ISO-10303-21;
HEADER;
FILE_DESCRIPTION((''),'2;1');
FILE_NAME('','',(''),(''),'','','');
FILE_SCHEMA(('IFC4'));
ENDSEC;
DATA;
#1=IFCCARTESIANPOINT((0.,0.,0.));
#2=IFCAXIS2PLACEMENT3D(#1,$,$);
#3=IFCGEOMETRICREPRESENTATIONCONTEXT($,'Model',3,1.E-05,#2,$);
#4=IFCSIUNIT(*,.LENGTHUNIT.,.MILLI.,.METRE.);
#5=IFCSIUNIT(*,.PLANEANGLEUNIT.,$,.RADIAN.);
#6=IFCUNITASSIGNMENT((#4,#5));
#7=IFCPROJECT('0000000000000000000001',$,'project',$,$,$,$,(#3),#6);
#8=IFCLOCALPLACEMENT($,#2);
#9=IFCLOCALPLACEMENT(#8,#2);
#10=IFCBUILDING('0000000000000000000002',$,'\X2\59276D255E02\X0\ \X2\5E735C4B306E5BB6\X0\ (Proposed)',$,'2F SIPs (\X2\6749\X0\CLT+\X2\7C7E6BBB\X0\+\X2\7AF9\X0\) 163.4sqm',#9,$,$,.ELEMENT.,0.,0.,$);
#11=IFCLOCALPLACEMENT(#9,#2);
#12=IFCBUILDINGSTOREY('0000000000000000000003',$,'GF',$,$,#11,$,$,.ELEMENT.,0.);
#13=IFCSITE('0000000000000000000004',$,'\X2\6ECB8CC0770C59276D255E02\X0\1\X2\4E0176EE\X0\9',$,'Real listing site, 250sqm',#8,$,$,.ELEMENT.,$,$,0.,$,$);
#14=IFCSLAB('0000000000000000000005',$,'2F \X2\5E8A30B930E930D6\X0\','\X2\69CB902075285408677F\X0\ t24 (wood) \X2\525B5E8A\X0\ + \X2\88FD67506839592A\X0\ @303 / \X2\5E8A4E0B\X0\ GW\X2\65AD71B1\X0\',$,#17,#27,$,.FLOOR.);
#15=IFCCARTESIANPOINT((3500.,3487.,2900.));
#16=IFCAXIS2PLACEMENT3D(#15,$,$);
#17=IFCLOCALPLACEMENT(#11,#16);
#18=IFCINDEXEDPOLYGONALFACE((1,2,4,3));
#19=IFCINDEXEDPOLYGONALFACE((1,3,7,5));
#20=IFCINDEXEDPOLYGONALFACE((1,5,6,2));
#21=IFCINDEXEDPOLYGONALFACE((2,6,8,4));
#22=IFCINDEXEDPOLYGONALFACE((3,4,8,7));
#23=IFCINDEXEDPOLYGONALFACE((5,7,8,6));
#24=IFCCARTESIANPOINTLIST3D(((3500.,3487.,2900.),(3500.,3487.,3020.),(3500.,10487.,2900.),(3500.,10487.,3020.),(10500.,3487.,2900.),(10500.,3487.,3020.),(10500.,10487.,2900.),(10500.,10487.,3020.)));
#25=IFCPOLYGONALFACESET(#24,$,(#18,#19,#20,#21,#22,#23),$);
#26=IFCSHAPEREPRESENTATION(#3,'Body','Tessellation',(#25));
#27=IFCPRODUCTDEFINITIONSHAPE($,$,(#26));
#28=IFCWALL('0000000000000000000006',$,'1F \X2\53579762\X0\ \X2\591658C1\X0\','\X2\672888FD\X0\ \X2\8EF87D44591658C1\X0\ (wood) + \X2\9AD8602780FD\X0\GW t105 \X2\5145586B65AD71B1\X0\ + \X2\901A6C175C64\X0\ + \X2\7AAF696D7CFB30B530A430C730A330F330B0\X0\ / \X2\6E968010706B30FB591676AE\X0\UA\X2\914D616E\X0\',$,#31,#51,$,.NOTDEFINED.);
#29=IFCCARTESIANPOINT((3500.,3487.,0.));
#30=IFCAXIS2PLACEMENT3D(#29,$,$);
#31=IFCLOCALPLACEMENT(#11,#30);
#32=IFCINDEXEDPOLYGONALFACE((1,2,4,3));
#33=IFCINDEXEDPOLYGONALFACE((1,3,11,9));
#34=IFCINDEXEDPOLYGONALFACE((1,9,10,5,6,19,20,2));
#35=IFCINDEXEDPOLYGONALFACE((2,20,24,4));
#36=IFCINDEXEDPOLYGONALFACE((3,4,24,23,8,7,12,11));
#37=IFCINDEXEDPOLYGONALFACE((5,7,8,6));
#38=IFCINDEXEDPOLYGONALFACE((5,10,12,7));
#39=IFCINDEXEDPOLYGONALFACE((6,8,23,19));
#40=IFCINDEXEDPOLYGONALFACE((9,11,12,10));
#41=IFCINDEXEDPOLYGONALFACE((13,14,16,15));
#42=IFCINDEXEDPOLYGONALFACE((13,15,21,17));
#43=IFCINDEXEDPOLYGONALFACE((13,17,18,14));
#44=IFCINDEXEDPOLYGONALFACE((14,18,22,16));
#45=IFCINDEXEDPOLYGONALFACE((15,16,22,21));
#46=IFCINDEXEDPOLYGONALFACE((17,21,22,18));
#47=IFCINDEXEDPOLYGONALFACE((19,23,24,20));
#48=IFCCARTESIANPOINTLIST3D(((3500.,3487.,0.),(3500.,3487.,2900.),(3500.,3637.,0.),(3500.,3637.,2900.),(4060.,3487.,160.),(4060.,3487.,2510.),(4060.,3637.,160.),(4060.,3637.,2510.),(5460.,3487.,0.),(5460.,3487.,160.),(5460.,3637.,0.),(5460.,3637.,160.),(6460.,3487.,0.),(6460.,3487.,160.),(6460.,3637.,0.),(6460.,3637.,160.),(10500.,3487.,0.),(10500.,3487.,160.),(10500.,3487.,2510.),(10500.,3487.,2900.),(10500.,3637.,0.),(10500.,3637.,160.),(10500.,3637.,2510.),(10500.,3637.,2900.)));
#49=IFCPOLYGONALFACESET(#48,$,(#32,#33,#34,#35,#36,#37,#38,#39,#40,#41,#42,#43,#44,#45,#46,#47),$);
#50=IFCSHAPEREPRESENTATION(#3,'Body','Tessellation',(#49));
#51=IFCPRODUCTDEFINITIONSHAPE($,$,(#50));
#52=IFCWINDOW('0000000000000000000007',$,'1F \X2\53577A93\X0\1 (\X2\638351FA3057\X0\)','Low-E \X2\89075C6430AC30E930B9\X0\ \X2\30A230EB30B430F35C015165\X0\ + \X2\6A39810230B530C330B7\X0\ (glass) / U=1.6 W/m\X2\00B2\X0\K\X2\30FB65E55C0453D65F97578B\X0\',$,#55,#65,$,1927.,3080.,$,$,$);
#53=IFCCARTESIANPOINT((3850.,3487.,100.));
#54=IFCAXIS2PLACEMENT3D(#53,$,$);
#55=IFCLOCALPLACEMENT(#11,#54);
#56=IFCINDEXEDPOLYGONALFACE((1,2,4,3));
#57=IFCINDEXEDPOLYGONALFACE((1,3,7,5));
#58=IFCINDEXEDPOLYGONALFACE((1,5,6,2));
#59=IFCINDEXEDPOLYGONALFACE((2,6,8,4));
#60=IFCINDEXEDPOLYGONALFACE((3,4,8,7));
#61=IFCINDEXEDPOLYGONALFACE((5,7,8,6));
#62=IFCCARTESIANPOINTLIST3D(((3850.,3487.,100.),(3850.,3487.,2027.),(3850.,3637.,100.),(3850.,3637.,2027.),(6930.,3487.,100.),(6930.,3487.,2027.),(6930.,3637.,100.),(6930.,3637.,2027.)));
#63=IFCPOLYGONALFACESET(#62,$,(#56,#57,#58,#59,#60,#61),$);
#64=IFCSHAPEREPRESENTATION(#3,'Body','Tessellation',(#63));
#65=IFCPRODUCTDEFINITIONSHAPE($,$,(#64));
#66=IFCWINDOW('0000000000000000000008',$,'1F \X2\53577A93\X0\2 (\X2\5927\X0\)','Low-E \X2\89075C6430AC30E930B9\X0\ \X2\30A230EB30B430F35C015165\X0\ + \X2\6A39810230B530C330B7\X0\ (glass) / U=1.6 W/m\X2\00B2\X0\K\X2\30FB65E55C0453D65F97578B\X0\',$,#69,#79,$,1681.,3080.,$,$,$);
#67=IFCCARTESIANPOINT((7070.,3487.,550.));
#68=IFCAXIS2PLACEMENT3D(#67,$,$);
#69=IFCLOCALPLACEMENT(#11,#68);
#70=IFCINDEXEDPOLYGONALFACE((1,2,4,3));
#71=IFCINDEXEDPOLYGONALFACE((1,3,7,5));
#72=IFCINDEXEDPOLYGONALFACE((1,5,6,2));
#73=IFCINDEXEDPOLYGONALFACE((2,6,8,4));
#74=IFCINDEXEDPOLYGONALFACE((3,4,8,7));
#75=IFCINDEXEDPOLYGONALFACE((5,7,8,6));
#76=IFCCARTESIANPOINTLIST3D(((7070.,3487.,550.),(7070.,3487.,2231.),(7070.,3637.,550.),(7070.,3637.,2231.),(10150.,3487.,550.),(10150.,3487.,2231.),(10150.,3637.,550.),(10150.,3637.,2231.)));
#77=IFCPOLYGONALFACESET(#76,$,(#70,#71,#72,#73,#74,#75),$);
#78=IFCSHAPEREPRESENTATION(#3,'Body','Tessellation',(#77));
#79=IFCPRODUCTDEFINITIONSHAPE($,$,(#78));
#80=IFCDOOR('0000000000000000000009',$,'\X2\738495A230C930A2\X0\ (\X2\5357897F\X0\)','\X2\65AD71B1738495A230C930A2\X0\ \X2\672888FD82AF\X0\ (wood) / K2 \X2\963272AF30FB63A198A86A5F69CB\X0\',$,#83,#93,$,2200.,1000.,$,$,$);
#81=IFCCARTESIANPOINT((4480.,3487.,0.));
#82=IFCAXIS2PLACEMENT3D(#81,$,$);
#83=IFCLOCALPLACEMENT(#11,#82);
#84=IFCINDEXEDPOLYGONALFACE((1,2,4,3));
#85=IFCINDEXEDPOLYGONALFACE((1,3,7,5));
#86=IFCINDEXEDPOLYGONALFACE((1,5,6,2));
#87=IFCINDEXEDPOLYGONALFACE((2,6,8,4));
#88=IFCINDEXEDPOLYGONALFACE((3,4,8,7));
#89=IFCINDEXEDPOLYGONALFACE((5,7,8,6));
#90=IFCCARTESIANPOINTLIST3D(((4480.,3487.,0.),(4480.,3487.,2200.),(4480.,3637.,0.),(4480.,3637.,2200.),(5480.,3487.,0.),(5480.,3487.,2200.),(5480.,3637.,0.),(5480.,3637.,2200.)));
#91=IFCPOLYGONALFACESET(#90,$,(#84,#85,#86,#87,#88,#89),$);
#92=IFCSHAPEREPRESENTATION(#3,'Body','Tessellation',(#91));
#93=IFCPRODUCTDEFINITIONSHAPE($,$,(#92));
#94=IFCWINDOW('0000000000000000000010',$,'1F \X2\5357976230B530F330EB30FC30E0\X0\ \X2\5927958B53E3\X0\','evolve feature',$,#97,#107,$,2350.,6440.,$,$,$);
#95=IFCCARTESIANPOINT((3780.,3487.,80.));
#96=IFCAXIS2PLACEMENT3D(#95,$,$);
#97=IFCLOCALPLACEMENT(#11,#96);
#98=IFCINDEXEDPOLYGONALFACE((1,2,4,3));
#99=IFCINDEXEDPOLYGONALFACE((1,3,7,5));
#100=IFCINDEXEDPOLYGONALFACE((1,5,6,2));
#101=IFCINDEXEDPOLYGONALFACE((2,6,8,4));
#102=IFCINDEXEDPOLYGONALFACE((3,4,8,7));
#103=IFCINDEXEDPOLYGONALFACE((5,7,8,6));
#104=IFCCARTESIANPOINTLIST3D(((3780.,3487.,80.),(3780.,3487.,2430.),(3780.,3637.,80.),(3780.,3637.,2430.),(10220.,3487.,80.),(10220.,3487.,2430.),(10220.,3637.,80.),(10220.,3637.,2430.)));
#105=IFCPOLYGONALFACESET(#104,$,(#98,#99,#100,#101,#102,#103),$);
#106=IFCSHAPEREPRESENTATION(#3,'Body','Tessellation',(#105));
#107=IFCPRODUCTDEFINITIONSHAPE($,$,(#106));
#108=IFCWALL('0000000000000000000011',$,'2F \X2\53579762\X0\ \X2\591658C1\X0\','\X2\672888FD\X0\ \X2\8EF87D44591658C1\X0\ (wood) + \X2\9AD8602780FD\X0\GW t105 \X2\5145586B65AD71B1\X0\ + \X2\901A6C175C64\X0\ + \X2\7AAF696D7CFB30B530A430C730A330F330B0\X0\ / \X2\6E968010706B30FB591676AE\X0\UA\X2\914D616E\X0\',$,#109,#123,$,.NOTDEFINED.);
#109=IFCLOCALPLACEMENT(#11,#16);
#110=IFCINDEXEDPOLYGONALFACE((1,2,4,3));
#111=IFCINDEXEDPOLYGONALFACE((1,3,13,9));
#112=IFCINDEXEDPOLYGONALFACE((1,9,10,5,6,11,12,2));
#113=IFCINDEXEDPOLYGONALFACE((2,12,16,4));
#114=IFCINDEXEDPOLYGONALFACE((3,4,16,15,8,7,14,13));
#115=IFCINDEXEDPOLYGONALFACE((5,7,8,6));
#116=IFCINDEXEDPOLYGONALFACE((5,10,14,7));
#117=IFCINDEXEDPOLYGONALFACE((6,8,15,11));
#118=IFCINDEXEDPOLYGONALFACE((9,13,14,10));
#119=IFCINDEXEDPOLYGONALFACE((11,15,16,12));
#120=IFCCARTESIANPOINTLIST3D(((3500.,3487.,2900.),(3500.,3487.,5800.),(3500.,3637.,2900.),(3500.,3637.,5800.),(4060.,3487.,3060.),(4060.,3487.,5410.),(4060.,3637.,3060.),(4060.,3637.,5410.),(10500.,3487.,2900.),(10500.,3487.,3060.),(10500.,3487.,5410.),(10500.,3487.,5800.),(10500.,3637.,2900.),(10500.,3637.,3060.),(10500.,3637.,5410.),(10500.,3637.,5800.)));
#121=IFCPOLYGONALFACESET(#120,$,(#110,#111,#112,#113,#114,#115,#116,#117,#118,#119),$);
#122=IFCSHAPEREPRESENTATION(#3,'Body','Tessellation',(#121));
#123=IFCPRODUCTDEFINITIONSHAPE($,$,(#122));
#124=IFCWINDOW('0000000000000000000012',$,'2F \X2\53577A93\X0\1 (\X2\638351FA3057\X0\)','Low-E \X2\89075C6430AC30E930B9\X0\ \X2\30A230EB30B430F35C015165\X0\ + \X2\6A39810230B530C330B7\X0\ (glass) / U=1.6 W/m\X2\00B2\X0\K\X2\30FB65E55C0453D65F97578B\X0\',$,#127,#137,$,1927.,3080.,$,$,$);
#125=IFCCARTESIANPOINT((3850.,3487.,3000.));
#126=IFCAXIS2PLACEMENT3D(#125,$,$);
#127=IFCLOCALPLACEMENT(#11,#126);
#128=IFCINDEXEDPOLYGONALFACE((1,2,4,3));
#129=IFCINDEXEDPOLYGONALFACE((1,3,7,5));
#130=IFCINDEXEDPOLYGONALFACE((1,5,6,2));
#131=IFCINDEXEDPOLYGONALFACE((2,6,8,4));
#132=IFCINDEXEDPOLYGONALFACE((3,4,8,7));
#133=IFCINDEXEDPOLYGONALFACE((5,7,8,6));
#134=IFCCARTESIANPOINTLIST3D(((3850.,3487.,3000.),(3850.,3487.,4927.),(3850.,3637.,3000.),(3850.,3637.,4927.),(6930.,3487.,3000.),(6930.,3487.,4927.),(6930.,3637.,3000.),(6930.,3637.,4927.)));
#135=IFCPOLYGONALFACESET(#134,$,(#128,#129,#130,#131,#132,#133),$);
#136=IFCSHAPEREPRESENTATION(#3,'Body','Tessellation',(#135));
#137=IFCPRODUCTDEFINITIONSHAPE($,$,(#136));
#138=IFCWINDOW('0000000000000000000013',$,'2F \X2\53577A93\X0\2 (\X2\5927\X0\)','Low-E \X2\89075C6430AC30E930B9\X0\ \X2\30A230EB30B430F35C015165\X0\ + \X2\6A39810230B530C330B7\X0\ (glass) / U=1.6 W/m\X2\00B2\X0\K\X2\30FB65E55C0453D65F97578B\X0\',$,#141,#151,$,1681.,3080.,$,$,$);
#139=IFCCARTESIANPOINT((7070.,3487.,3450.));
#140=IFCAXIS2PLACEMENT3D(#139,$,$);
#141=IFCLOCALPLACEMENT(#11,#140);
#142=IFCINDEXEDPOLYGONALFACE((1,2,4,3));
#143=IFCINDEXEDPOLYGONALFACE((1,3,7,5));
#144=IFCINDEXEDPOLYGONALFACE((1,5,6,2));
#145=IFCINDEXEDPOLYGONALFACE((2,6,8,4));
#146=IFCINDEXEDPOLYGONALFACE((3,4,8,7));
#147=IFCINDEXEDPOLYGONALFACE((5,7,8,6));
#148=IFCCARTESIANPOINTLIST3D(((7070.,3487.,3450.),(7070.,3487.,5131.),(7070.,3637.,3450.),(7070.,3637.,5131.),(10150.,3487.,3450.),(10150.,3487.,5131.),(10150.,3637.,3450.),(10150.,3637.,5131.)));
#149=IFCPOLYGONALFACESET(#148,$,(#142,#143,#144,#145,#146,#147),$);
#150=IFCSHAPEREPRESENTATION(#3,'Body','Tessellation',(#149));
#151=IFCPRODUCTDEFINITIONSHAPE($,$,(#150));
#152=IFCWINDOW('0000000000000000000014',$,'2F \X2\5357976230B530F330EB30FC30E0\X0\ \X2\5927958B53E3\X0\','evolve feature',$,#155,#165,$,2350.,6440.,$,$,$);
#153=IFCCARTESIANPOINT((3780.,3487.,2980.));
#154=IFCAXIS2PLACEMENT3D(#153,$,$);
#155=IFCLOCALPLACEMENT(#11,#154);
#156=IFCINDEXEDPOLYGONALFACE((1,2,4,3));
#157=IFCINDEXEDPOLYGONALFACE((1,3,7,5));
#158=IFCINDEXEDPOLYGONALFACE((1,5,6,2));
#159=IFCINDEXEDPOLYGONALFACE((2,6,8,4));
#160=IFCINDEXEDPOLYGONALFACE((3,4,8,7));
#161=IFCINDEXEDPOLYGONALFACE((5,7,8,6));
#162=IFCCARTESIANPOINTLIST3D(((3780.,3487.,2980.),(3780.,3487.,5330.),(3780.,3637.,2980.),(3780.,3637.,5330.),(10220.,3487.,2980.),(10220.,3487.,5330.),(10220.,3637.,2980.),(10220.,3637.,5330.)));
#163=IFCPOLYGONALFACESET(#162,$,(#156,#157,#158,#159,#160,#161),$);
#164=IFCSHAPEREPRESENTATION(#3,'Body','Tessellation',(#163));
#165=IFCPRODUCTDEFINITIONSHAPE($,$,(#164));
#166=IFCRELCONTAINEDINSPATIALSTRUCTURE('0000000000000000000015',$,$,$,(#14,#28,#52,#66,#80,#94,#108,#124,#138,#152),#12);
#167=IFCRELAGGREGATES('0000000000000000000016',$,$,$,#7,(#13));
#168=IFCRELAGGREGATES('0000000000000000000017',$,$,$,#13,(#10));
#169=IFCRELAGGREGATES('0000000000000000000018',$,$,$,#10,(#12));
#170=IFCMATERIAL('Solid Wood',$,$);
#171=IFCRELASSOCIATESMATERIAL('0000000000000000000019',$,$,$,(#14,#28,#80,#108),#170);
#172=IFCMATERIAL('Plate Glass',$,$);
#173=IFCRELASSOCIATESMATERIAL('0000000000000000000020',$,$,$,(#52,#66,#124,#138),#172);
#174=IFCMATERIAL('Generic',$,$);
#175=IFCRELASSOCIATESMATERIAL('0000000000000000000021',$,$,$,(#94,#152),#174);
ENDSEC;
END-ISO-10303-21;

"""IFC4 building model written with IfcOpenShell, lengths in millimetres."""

from ifc_helpers import new_model, si_unit, frame, frame_2d, origin, place, context, project, spatial, rectangle, extrude, material, element, fill, save


model = new_model("IFC4")

# Units and contexts
model_context = context("Model", 3, precision=1e-05, world=origin())
ifc_project = project(units=[si_unit("LENGTHUNIT", "METRE", prefix="MILLI"), si_unit("PLANEANGLEUNIT", "RADIAN")], contexts=[model_context])

# Site, building, storey
site_placement = place(None, origin())
site = spatial("IfcSite", under=ifc_project, at=site_placement, Name="滋賀県大津市1丁目9", ObjectType="Real listing site, 250sqm", CompositionType="ELEMENT", RefElevation=0.0)
building_placement = place(site_placement, origin())
building = spatial("IfcBuilding", under=site, at=building_placement, Name="大津市 平屋の家 (Proposed)", ObjectType="2F SIPs (杉CLT+籾殻+竹) 163.4sqm", CompositionType="ELEMENT", ElevationOfRefHeight=0.0, ElevationOfTerrain=0.0)
storey_placement = place(building_placement, origin())
storey = spatial("IfcBuildingStorey", under=building, at=storey_placement, Name="GF", CompositionType="ELEMENT", Elevation=0.0)

# Slab
ifc_material_1 = material(Name="Solid Wood")
slab_1_placement = place(storey_placement, frame((3500.0, 3487.0, 2900.0)))
element("IfcSlab", 1, at=slab_1_placement, inside=storey, material=ifc_material_1, Name="2F 床スラブ", Description="構造用合板 t24 (wood) 剛床 + 製材根太 @303 / 床下 GW断熱", PredefinedType="FLOOR", context=model_context, shape_type="SweptSolid", body=[
    extrude(rectangle(XDim=7000.0, YDim=7000.0, at=frame_2d((3500.0, 3500.0))), frame((3500.0, 3487.0, 2900.0)), (0.0, 0.0, 1.0), 120.0),
])
ifc_material_2 = material(Name="Generic")

# Wall, openings, windows, door
wall_1_placement = place(storey_placement, frame((3500.0, 3487.0, 0.0)))
wall_1 = element("IfcWall", 2, at=wall_1_placement, inside=storey, material=ifc_material_1, Name="1F 南面 外壁", Description="木製 軸組外壁 (wood) + 高性能GW t105 充填断熱 + 通気層 + 窯業系サイディング / 準耐火・外皮UA配慮", PredefinedType="NOTDEFINED", context=model_context, shape_type="SweptSolid", body=[
    extrude(rectangle(XDim=7000.0, YDim=150.0, at=frame_2d((3500.0, 75.0))), frame((3500.0, 3487.0, 0.0)), (0.0, 0.0, 1.0), 2900.0),
])
opening_1_placement = place(storey_placement, frame((3850.0, 3487.0, 100.0)))
opening_1 = element("IfcOpeningElement", 3, at=opening_1_placement, cuts=wall_1, PredefinedType="NOTDEFINED", context=model_context, shape_type="SweptSolid", body=[
    extrude(rectangle(XDim=3080.0, YDim=150.0, at=frame_2d((1540.0, 75.0))), frame((3850.0, 3487.0, 100.0)), (0.0, 0.0, 1.0), 1927.0),
])
opening_2_placement = place(storey_placement, frame((7070.0, 3487.0, 550.0)))
opening_2 = element("IfcOpeningElement", 4, at=opening_2_placement, cuts=wall_1, PredefinedType="NOTDEFINED", context=model_context, shape_type="SweptSolid", body=[
    extrude(rectangle(XDim=3080.0, YDim=150.0, at=frame_2d((1540.0, 75.0))), frame((7070.0, 3487.0, 550.0)), (0.0, 0.0, 1.0), 1681.0),
])
opening_3_placement = place(storey_placement, frame((4480.0, 3487.0, 0.0)))
opening_3 = element("IfcOpeningElement", 5, at=opening_3_placement, cuts=wall_1, PredefinedType="NOTDEFINED", context=model_context, shape_type="SweptSolid", body=[
    extrude(rectangle(XDim=1000.0, YDim=150.0, at=frame_2d((500.0, 75.0))), frame((4480.0, 3487.0, 0.0)), (0.0, 0.0, 1.0), 2200.0),
])
opening_4_placement = place(storey_placement, frame((3780.0, 3487.0, 80.0)))
opening_4 = element("IfcOpeningElement", 6, at=opening_4_placement, cuts=wall_1, PredefinedType="NOTDEFINED", context=model_context, shape_type="SweptSolid", body=[
    extrude(rectangle(XDim=6440.0, YDim=150.0, at=frame_2d((3220.0, 75.0))), frame((3780.0, 3487.0, 80.0)), (0.0, 0.0, 1.0), 2350.0),
])
ifc_material_3 = material(Name="Plate Glass")
window_1_placement = place(storey_placement, frame((3850.0, 3487.0, 100.0)))
window_1 = element("IfcWindow", 7, at=window_1_placement, inside=storey, material=ifc_material_3, Name="1F 南窓1 (掃出し)", Description="Low-E 複層ガラス アルゴン封入 + 樹脂サッシ (glass) / U=1.6 W/m²K・日射取得型", OverallHeight=1927.0, OverallWidth=3080.0, context=model_context, shape_type="SweptSolid", body=[
    extrude(rectangle(XDim=3080.0, YDim=150.0, at=frame_2d((1540.0, 75.0))), frame((3850.0, 3487.0, 100.0)), (0.0, 0.0, 1.0), 1927.0),
])
fill(opening_1, window_1)
window_2_placement = place(storey_placement, frame((7070.0, 3487.0, 550.0)))
window_2 = element("IfcWindow", 8, at=window_2_placement, inside=storey, material=ifc_material_3, Name="1F 南窓2 (大)", Description="Low-E 複層ガラス アルゴン封入 + 樹脂サッシ (glass) / U=1.6 W/m²K・日射取得型", OverallHeight=1681.0, OverallWidth=3080.0, context=model_context, shape_type="SweptSolid", body=[
    extrude(rectangle(XDim=3080.0, YDim=150.0, at=frame_2d((1540.0, 75.0))), frame((7070.0, 3487.0, 550.0)), (0.0, 0.0, 1.0), 1681.0),
])
fill(opening_2, window_2)
door_placement = place(storey_placement, frame((4480.0, 3487.0, 0.0)))
door = element("IfcDoor", 9, at=door_placement, inside=storey, material=ifc_material_1, Name="玄関ドア (南西)", Description="断熱玄関ドア 木製芯 (wood) / K2 防犯・採風機構", OverallHeight=2200.0, OverallWidth=1000.0, context=model_context, shape_type="SweptSolid", body=[
    extrude(rectangle(XDim=1000.0, YDim=150.0, at=frame_2d((500.0, 75.0))), frame((4480.0, 3487.0, 0.0)), (0.0, 0.0, 1.0), 2200.0),
])
fill(opening_3, door)
window_3_placement = place(storey_placement, frame((3780.0, 3487.0, 80.0)))
window_3 = element("IfcWindow", 10, at=window_3_placement, inside=storey, material=ifc_material_2, Name="1F 南面サンルーム 大開口", Description="evolve feature", OverallHeight=2350.0, OverallWidth=6440.0, context=model_context, shape_type="SweptSolid", body=[
    extrude(rectangle(XDim=6440.0, YDim=150.0, at=frame_2d((3220.0, 75.0))), frame((3780.0, 3487.0, 80.0)), (0.0, 0.0, 1.0), 2350.0),
])
fill(opening_4, window_3)

# Wall, openings, windows
wall_2_placement = place(storey_placement, frame((3500.0, 3487.0, 2900.0)))
wall_2 = element("IfcWall", 11, at=wall_2_placement, inside=storey, material=ifc_material_1, Name="2F 南面 外壁", Description="木製 軸組外壁 (wood) + 高性能GW t105 充填断熱 + 通気層 + 窯業系サイディング / 準耐火・外皮UA配慮", PredefinedType="NOTDEFINED", context=model_context, shape_type="SweptSolid", body=[
    extrude(rectangle(XDim=7000.0, YDim=150.0, at=frame_2d((3500.0, 75.0))), frame((3500.0, 3487.0, 2900.0)), (0.0, 0.0, 1.0), 2900.0),
])
opening_5_placement = place(storey_placement, frame((3850.0, 3487.0, 3000.0)))
opening_5 = element("IfcOpeningElement", 12, at=opening_5_placement, cuts=wall_2, PredefinedType="NOTDEFINED", context=model_context, shape_type="SweptSolid", body=[
    extrude(rectangle(XDim=3080.0, YDim=150.0, at=frame_2d((1540.0, 75.0))), frame((3850.0, 3487.0, 3000.0)), (0.0, 0.0, 1.0), 1927.0),
])
opening_6_placement = place(storey_placement, frame((7070.0, 3487.0, 3450.0)))
opening_6 = element("IfcOpeningElement", 13, at=opening_6_placement, cuts=wall_2, PredefinedType="NOTDEFINED", context=model_context, shape_type="SweptSolid", body=[
    extrude(rectangle(XDim=3080.0, YDim=150.0, at=frame_2d((1540.0, 75.0))), frame((7070.0, 3487.0, 3450.0)), (0.0, 0.0, 1.0), 1681.0),
])
opening_7_placement = place(storey_placement, frame((3780.0, 3487.0, 2980.0)))
opening_7 = element("IfcOpeningElement", 14, at=opening_7_placement, cuts=wall_2, PredefinedType="NOTDEFINED", context=model_context, shape_type="SweptSolid", body=[
    extrude(rectangle(XDim=6440.0, YDim=150.0, at=frame_2d((3220.0, 75.0))), frame((3780.0, 3487.0, 2980.0)), (0.0, 0.0, 1.0), 2350.0),
])
window_4_placement = place(storey_placement, frame((3850.0, 3487.0, 3000.0)))
window_4 = element("IfcWindow", 15, at=window_4_placement, inside=storey, material=ifc_material_3, Name="2F 南窓1 (掃出し)", Description="Low-E 複層ガラス アルゴン封入 + 樹脂サッシ (glass) / U=1.6 W/m²K・日射取得型", OverallHeight=1927.0, OverallWidth=3080.0, context=model_context, shape_type="SweptSolid", body=[
    extrude(rectangle(XDim=3080.0, YDim=150.0, at=frame_2d((1540.0, 75.0))), frame((3850.0, 3487.0, 3000.0)), (0.0, 0.0, 1.0), 1927.0),
])
fill(opening_5, window_4)
window_5_placement = place(storey_placement, frame((7070.0, 3487.0, 3450.0)))
window_5 = element("IfcWindow", 16, at=window_5_placement, inside=storey, material=ifc_material_3, Name="2F 南窓2 (大)", Description="Low-E 複層ガラス アルゴン封入 + 樹脂サッシ (glass) / U=1.6 W/m²K・日射取得型", OverallHeight=1681.0, OverallWidth=3080.0, context=model_context, shape_type="SweptSolid", body=[
    extrude(rectangle(XDim=3080.0, YDim=150.0, at=frame_2d((1540.0, 75.0))), frame((7070.0, 3487.0, 3450.0)), (0.0, 0.0, 1.0), 1681.0),
])
fill(opening_6, window_5)
window_6_placement = place(storey_placement, frame((3780.0, 3487.0, 2980.0)))
window_6 = element("IfcWindow", 17, at=window_6_placement, inside=storey, material=ifc_material_2, Name="2F 南面サンルーム 大開口", Description="evolve feature", OverallHeight=2350.0, OverallWidth=6440.0, context=model_context, shape_type="SweptSolid", body=[
    extrude(rectangle(XDim=6440.0, YDim=150.0, at=frame_2d((3220.0, 75.0))), frame((3780.0, 3487.0, 2980.0)), (0.0, 0.0, 1.0), 2350.0),
])
fill(opening_7, window_6)

save(model, "model.ifc")
